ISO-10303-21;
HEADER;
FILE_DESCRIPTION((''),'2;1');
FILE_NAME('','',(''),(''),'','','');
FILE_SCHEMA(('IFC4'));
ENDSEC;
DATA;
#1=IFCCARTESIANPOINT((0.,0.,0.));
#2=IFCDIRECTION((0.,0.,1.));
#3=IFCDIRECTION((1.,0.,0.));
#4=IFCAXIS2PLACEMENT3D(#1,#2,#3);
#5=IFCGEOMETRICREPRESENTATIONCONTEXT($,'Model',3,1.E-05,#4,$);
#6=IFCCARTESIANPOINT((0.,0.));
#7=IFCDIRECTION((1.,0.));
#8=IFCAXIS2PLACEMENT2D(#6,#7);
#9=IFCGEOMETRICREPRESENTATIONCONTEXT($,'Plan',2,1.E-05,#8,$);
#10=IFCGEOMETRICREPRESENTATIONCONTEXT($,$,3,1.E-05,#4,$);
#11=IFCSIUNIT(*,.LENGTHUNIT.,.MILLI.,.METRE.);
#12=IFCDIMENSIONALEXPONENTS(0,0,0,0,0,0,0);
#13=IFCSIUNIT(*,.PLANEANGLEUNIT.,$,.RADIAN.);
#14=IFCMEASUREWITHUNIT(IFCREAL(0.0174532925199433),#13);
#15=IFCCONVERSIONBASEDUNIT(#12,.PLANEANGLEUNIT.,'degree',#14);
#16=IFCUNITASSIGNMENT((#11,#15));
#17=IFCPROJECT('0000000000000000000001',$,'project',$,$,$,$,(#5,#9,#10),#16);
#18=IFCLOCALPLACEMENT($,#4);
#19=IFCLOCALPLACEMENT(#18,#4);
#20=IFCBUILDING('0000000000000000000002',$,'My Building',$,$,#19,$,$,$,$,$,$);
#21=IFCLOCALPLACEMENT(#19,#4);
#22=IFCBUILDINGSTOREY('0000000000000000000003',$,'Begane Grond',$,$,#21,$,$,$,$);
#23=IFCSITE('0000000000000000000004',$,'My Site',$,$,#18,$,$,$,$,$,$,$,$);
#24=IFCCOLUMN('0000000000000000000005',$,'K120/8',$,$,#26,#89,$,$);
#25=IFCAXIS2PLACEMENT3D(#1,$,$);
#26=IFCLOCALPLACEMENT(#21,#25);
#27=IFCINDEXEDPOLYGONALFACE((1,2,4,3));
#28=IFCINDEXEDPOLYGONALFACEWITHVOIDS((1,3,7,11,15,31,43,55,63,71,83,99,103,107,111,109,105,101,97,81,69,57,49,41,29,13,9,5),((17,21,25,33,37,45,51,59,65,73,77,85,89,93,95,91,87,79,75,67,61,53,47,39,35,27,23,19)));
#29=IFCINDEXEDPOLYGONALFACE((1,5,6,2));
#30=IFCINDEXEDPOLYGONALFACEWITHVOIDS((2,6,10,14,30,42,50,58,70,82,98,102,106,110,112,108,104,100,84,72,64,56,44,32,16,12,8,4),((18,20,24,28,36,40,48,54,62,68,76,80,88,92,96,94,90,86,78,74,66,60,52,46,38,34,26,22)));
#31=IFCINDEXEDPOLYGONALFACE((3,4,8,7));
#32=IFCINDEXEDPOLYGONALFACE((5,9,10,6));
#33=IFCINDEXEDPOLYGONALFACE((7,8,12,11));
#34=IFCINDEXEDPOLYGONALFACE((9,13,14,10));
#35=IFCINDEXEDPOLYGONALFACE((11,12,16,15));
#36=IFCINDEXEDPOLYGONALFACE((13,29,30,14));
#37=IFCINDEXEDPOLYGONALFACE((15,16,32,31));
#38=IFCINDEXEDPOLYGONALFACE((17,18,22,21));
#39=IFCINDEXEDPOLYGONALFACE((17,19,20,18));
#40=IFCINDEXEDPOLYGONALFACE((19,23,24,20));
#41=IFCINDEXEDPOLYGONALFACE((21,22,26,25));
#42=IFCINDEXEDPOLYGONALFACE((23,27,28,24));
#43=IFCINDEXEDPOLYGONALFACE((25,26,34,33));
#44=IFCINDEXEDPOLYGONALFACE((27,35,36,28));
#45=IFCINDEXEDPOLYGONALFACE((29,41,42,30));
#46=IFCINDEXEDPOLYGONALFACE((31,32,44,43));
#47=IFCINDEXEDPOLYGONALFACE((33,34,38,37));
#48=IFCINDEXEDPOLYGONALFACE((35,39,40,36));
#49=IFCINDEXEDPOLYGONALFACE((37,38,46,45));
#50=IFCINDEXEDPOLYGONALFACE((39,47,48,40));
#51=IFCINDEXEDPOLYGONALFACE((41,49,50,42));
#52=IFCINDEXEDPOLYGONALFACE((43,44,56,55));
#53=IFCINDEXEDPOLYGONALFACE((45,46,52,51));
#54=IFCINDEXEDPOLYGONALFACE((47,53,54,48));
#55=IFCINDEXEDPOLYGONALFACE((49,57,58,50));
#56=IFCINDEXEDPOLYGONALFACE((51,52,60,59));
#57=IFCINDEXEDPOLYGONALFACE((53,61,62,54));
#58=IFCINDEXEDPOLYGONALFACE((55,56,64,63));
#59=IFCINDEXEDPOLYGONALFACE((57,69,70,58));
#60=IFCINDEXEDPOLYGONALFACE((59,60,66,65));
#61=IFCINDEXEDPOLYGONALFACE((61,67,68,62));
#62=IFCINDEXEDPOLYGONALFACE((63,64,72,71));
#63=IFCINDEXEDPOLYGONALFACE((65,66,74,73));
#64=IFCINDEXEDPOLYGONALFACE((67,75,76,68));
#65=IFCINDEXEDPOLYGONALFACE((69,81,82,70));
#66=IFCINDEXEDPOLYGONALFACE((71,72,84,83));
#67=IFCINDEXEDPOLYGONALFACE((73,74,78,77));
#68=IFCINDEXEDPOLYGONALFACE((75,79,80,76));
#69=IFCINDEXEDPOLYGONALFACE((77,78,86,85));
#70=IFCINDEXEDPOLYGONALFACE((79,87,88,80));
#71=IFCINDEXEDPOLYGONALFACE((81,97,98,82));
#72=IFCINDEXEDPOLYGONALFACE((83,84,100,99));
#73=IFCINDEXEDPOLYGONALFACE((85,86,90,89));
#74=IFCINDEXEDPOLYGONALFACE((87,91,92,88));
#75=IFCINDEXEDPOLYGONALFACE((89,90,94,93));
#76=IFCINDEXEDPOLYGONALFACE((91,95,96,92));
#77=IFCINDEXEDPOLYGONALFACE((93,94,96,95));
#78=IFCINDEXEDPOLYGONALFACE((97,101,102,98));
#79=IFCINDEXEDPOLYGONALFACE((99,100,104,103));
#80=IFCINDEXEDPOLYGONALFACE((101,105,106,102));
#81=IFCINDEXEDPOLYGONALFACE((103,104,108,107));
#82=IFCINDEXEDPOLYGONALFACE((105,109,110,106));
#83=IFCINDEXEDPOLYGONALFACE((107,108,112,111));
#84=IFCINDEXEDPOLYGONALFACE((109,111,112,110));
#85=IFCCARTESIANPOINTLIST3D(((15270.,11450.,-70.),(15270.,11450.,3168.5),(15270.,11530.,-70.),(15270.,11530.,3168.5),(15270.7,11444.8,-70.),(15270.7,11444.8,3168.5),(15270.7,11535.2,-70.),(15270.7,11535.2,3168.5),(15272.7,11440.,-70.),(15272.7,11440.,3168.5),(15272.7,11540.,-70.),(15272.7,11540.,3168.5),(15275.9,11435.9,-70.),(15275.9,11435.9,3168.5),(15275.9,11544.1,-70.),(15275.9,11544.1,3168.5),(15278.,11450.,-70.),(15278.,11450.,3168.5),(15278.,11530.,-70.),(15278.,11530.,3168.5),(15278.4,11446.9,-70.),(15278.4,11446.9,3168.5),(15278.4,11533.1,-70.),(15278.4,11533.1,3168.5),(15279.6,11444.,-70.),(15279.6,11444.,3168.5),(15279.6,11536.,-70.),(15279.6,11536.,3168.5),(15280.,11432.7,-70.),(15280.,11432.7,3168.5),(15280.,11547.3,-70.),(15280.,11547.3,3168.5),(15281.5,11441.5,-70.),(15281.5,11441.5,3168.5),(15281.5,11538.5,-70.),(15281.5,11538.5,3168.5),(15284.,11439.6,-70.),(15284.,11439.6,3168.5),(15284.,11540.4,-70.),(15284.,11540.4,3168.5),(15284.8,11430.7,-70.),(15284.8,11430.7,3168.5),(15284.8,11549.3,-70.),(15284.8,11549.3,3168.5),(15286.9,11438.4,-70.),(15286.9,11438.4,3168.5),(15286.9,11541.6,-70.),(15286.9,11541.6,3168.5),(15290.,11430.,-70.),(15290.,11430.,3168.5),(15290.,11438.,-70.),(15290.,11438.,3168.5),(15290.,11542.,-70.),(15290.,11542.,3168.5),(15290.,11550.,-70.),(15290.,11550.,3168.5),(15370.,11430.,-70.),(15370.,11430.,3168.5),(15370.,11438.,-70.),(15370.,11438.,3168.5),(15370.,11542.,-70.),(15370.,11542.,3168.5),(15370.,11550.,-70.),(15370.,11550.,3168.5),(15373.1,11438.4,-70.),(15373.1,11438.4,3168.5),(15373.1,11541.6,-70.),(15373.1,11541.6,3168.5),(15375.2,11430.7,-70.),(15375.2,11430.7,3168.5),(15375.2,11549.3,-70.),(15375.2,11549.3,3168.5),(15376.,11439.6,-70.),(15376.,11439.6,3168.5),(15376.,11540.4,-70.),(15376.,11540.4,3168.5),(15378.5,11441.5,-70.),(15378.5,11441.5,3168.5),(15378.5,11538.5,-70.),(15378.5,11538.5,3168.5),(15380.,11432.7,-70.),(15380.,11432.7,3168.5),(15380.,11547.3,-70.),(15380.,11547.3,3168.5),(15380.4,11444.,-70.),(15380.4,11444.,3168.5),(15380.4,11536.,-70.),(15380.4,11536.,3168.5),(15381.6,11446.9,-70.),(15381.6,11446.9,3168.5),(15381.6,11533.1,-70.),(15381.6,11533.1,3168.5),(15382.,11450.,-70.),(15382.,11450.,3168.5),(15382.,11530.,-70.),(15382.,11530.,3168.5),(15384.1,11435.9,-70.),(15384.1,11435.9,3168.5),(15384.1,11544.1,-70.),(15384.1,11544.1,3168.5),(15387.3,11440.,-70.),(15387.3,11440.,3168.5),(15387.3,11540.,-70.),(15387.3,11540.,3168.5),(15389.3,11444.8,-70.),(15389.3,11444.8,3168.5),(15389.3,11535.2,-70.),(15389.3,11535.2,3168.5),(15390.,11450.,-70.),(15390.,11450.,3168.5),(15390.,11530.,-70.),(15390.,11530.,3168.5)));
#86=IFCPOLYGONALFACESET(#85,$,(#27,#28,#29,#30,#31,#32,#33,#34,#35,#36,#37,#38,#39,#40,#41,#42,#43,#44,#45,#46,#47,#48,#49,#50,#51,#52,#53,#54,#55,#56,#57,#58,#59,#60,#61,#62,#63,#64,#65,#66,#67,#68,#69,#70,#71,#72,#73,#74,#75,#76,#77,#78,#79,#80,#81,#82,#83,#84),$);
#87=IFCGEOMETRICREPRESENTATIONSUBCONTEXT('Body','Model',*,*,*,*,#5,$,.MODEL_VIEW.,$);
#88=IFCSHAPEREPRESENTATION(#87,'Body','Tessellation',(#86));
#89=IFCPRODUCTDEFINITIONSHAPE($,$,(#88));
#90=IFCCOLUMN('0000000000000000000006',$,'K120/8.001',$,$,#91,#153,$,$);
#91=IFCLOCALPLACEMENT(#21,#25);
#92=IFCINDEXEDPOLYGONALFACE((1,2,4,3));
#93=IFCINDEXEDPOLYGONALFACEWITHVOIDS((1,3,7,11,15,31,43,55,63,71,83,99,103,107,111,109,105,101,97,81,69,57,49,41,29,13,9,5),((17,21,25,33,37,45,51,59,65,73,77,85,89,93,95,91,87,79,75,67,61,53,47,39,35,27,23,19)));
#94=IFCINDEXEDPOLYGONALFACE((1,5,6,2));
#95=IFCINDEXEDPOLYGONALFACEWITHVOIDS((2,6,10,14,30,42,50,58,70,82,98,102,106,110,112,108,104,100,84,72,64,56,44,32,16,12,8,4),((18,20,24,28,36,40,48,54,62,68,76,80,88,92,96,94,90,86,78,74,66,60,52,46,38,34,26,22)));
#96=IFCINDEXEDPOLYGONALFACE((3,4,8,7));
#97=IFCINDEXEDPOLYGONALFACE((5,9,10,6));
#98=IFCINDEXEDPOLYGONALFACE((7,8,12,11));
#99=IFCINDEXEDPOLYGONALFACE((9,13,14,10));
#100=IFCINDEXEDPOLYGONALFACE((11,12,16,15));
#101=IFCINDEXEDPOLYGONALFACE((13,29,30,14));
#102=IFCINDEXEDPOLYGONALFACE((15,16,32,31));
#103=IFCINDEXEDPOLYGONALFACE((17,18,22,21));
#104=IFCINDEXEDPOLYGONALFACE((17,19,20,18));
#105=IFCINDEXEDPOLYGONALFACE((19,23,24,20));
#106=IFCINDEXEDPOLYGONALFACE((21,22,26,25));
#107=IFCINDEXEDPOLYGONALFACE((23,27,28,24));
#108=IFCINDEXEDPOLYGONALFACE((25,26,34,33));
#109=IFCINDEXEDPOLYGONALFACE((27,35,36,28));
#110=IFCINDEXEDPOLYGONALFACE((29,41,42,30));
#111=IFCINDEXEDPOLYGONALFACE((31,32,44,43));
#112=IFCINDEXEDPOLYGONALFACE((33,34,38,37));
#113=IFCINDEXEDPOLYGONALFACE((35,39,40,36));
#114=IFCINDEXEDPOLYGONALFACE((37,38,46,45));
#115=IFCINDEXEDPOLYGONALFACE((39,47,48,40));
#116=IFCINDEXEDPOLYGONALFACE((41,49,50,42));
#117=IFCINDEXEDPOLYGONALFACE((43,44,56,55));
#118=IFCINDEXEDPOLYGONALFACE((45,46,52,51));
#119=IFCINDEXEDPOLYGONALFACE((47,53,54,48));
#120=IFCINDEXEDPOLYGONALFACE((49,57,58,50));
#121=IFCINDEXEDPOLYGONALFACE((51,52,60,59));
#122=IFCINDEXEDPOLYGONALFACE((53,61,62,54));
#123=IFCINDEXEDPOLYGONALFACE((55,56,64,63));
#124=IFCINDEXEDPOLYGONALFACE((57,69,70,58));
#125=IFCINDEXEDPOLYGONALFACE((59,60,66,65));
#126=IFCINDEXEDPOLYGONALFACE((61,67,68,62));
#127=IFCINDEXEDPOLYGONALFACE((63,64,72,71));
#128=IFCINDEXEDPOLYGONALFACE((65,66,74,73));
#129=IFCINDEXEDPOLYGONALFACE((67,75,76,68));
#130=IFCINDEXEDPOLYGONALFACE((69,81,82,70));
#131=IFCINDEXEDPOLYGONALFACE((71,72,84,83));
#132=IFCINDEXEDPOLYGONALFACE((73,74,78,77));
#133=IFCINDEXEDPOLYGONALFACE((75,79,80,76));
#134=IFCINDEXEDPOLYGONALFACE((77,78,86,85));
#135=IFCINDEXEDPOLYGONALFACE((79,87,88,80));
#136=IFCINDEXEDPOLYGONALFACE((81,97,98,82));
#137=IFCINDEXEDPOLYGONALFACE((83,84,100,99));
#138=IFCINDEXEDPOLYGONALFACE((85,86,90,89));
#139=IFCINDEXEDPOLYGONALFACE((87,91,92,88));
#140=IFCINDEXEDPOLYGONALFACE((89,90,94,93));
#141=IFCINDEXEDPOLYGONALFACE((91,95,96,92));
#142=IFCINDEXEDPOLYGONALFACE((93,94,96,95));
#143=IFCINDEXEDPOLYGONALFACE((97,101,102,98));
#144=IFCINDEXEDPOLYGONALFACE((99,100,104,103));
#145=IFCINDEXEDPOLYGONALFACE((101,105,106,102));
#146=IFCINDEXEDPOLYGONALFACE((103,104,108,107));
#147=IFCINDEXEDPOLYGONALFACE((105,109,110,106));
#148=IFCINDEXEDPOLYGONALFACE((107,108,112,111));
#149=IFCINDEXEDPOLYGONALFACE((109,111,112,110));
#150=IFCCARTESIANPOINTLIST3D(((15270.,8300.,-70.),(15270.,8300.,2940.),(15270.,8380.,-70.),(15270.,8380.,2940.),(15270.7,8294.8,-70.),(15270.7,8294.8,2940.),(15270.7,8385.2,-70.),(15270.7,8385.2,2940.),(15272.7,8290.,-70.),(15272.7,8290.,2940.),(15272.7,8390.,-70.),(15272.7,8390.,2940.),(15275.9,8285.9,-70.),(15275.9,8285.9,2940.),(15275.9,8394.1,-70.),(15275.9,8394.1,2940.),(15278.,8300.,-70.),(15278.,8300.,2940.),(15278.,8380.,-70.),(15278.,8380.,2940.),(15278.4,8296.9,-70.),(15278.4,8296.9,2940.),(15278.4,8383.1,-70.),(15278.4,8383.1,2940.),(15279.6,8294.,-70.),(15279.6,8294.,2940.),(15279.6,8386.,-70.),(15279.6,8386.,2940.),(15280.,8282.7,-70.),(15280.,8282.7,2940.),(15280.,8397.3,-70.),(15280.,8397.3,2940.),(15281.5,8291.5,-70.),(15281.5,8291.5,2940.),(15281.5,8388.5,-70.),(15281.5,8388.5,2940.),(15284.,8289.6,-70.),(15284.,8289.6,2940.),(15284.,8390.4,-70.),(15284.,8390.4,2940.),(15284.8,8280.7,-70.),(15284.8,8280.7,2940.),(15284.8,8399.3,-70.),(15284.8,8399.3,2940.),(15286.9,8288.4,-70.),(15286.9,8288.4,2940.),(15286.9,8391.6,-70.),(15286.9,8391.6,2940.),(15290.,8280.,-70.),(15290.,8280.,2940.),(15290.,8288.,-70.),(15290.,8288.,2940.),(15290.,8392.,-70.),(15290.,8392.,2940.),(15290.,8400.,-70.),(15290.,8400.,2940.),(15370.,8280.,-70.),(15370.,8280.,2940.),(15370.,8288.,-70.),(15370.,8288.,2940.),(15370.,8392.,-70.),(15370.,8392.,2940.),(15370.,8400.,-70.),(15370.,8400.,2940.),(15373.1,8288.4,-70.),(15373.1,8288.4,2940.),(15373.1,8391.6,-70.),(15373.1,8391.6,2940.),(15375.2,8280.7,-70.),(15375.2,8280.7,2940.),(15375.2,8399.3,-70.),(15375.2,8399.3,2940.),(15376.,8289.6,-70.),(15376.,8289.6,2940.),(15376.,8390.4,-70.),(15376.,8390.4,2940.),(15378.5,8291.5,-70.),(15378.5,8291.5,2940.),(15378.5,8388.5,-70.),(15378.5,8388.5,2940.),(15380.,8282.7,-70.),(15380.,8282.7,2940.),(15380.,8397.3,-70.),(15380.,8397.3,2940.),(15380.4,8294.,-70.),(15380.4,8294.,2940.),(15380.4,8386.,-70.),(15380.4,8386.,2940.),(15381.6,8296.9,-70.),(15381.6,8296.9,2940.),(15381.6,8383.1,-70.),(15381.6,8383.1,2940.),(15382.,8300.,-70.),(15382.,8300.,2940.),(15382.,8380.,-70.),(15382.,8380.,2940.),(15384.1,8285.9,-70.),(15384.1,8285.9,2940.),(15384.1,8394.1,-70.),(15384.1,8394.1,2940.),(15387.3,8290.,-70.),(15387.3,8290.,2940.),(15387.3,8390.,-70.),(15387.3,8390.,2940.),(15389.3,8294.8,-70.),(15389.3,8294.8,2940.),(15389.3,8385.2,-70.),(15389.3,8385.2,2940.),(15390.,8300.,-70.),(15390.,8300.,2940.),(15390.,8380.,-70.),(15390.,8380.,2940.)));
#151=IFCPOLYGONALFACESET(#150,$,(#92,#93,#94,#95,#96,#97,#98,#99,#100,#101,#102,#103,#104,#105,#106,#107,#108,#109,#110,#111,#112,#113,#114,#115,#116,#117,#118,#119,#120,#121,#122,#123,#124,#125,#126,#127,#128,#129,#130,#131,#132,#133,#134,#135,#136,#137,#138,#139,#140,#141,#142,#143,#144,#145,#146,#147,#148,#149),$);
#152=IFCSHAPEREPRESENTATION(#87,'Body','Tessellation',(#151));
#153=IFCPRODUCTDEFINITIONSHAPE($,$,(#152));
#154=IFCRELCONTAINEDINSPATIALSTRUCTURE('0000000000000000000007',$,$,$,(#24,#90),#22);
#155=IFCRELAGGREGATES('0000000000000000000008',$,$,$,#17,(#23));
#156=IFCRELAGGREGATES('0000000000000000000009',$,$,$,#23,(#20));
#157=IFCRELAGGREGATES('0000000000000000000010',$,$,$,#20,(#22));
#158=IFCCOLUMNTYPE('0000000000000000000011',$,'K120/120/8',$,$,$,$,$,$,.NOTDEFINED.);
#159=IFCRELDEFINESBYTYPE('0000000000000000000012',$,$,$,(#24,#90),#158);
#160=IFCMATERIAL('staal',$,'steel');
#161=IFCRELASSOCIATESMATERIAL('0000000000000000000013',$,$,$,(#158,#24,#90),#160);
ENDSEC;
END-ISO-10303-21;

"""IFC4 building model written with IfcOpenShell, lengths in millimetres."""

from ifc_helpers import new_model, entity, si_unit, converted_unit, frame, origin_with_axes, origin_2d_with_axis, place, context, subcontext, project, spatial, hollow_rectangle, extrude, material, material_profile, profile_set, profile_usage, type_object, element, save


model = new_model("IFC4")

# Units and contexts
model_context = context("Model", 3, precision=1e-05, world=origin_with_axes())
plan_context = context("Plan", 2, precision=1e-05, world=origin_2d_with_axis())
context_of_model = context(None, 3, precision=1e-05, world=origin_with_axes())
body_context = subcontext(model_context, "Body", "Model", "MODEL_VIEW")
ifc_project = project(units=[si_unit("LENGTHUNIT", "METRE", prefix="MILLI"), converted_unit("PLANEANGLEUNIT", "degree", entity("IfcReal", 0.0174532925199433), si_unit("PLANEANGLEUNIT", "RADIAN"), dimensions=[0, 0, 0, 0, 0, 0, 0])], contexts=[model_context, plan_context, context_of_model])

# Site, building, storey
site_placement = place(None, origin_with_axes())
site = spatial("IfcSite", under=ifc_project, at=site_placement, Name="My Site")
building_placement = place(site_placement, origin_with_axes())
building = spatial("IfcBuilding", under=site, at=building_placement, Name="My Building")
storey_placement = place(building_placement, origin_with_axes())
storey = spatial("IfcBuildingStorey", under=building, at=storey_placement, Name="Begane Grond")

# Columns
ifc_material = material(Name="staal", Category="steel")
ifc_material_profile_1 = material_profile(ifc_material, hollow_rectangle(XDim=120.0, YDim=120.0, WallThickness=8.0, InnerFilletRadius=12.0, OuterFilletRadius=20.0))
ifc_profile_set_1 = profile_set([ifc_material_profile_1], Name="K120/120/8")
ifc_profile_usage_1 = profile_usage(ifc_profile_set_1)
column_type_1 = type_object("IfcColumnType", Name="K120/120/8", PredefinedType="NOTDEFINED", material=ifc_profile_set_1)
column_1_placement = place(storey_placement, frame((15330.0, 11490.0, -70.0), z_axis=(0.0, 0.0, 1.0), x_axis=(1.0, 0.0, 0.0)))
element("IfcColumn", 1, at=column_1_placement, inside=storey, type_object=column_type_1, material=ifc_profile_usage_1, Name="K120/8", context=body_context, shape_type="SweptSolid", body=[
    extrude(hollow_rectangle(XDim=120.0, YDim=120.0, WallThickness=8.0, InnerFilletRadius=12.0, OuterFilletRadius=20.0), origin_with_axes(), (0.0, 0.0, 1.0), 3238.5),
])
ifc_profile_usage_2 = profile_usage(ifc_profile_set_1)
column_2_placement = place(storey_placement, frame((15330.0, 8340.0, -70.0), z_axis=(0.0, 0.0, 1.0), x_axis=(1.0, 0.0, 0.0)))
element("IfcColumn", 2, at=column_2_placement, inside=storey, type_object=column_type_1, material=ifc_profile_usage_2, Name="K120/8.001", context=body_context, shape_type="SweptSolid", body=[
    extrude(hollow_rectangle(XDim=120.0, YDim=120.0, WallThickness=8.0, InnerFilletRadius=12.0, OuterFilletRadius=20.0), origin_with_axes(), (0.0, 0.0, 1.0), 3010.0),
])

save(model, "model.ifc")
